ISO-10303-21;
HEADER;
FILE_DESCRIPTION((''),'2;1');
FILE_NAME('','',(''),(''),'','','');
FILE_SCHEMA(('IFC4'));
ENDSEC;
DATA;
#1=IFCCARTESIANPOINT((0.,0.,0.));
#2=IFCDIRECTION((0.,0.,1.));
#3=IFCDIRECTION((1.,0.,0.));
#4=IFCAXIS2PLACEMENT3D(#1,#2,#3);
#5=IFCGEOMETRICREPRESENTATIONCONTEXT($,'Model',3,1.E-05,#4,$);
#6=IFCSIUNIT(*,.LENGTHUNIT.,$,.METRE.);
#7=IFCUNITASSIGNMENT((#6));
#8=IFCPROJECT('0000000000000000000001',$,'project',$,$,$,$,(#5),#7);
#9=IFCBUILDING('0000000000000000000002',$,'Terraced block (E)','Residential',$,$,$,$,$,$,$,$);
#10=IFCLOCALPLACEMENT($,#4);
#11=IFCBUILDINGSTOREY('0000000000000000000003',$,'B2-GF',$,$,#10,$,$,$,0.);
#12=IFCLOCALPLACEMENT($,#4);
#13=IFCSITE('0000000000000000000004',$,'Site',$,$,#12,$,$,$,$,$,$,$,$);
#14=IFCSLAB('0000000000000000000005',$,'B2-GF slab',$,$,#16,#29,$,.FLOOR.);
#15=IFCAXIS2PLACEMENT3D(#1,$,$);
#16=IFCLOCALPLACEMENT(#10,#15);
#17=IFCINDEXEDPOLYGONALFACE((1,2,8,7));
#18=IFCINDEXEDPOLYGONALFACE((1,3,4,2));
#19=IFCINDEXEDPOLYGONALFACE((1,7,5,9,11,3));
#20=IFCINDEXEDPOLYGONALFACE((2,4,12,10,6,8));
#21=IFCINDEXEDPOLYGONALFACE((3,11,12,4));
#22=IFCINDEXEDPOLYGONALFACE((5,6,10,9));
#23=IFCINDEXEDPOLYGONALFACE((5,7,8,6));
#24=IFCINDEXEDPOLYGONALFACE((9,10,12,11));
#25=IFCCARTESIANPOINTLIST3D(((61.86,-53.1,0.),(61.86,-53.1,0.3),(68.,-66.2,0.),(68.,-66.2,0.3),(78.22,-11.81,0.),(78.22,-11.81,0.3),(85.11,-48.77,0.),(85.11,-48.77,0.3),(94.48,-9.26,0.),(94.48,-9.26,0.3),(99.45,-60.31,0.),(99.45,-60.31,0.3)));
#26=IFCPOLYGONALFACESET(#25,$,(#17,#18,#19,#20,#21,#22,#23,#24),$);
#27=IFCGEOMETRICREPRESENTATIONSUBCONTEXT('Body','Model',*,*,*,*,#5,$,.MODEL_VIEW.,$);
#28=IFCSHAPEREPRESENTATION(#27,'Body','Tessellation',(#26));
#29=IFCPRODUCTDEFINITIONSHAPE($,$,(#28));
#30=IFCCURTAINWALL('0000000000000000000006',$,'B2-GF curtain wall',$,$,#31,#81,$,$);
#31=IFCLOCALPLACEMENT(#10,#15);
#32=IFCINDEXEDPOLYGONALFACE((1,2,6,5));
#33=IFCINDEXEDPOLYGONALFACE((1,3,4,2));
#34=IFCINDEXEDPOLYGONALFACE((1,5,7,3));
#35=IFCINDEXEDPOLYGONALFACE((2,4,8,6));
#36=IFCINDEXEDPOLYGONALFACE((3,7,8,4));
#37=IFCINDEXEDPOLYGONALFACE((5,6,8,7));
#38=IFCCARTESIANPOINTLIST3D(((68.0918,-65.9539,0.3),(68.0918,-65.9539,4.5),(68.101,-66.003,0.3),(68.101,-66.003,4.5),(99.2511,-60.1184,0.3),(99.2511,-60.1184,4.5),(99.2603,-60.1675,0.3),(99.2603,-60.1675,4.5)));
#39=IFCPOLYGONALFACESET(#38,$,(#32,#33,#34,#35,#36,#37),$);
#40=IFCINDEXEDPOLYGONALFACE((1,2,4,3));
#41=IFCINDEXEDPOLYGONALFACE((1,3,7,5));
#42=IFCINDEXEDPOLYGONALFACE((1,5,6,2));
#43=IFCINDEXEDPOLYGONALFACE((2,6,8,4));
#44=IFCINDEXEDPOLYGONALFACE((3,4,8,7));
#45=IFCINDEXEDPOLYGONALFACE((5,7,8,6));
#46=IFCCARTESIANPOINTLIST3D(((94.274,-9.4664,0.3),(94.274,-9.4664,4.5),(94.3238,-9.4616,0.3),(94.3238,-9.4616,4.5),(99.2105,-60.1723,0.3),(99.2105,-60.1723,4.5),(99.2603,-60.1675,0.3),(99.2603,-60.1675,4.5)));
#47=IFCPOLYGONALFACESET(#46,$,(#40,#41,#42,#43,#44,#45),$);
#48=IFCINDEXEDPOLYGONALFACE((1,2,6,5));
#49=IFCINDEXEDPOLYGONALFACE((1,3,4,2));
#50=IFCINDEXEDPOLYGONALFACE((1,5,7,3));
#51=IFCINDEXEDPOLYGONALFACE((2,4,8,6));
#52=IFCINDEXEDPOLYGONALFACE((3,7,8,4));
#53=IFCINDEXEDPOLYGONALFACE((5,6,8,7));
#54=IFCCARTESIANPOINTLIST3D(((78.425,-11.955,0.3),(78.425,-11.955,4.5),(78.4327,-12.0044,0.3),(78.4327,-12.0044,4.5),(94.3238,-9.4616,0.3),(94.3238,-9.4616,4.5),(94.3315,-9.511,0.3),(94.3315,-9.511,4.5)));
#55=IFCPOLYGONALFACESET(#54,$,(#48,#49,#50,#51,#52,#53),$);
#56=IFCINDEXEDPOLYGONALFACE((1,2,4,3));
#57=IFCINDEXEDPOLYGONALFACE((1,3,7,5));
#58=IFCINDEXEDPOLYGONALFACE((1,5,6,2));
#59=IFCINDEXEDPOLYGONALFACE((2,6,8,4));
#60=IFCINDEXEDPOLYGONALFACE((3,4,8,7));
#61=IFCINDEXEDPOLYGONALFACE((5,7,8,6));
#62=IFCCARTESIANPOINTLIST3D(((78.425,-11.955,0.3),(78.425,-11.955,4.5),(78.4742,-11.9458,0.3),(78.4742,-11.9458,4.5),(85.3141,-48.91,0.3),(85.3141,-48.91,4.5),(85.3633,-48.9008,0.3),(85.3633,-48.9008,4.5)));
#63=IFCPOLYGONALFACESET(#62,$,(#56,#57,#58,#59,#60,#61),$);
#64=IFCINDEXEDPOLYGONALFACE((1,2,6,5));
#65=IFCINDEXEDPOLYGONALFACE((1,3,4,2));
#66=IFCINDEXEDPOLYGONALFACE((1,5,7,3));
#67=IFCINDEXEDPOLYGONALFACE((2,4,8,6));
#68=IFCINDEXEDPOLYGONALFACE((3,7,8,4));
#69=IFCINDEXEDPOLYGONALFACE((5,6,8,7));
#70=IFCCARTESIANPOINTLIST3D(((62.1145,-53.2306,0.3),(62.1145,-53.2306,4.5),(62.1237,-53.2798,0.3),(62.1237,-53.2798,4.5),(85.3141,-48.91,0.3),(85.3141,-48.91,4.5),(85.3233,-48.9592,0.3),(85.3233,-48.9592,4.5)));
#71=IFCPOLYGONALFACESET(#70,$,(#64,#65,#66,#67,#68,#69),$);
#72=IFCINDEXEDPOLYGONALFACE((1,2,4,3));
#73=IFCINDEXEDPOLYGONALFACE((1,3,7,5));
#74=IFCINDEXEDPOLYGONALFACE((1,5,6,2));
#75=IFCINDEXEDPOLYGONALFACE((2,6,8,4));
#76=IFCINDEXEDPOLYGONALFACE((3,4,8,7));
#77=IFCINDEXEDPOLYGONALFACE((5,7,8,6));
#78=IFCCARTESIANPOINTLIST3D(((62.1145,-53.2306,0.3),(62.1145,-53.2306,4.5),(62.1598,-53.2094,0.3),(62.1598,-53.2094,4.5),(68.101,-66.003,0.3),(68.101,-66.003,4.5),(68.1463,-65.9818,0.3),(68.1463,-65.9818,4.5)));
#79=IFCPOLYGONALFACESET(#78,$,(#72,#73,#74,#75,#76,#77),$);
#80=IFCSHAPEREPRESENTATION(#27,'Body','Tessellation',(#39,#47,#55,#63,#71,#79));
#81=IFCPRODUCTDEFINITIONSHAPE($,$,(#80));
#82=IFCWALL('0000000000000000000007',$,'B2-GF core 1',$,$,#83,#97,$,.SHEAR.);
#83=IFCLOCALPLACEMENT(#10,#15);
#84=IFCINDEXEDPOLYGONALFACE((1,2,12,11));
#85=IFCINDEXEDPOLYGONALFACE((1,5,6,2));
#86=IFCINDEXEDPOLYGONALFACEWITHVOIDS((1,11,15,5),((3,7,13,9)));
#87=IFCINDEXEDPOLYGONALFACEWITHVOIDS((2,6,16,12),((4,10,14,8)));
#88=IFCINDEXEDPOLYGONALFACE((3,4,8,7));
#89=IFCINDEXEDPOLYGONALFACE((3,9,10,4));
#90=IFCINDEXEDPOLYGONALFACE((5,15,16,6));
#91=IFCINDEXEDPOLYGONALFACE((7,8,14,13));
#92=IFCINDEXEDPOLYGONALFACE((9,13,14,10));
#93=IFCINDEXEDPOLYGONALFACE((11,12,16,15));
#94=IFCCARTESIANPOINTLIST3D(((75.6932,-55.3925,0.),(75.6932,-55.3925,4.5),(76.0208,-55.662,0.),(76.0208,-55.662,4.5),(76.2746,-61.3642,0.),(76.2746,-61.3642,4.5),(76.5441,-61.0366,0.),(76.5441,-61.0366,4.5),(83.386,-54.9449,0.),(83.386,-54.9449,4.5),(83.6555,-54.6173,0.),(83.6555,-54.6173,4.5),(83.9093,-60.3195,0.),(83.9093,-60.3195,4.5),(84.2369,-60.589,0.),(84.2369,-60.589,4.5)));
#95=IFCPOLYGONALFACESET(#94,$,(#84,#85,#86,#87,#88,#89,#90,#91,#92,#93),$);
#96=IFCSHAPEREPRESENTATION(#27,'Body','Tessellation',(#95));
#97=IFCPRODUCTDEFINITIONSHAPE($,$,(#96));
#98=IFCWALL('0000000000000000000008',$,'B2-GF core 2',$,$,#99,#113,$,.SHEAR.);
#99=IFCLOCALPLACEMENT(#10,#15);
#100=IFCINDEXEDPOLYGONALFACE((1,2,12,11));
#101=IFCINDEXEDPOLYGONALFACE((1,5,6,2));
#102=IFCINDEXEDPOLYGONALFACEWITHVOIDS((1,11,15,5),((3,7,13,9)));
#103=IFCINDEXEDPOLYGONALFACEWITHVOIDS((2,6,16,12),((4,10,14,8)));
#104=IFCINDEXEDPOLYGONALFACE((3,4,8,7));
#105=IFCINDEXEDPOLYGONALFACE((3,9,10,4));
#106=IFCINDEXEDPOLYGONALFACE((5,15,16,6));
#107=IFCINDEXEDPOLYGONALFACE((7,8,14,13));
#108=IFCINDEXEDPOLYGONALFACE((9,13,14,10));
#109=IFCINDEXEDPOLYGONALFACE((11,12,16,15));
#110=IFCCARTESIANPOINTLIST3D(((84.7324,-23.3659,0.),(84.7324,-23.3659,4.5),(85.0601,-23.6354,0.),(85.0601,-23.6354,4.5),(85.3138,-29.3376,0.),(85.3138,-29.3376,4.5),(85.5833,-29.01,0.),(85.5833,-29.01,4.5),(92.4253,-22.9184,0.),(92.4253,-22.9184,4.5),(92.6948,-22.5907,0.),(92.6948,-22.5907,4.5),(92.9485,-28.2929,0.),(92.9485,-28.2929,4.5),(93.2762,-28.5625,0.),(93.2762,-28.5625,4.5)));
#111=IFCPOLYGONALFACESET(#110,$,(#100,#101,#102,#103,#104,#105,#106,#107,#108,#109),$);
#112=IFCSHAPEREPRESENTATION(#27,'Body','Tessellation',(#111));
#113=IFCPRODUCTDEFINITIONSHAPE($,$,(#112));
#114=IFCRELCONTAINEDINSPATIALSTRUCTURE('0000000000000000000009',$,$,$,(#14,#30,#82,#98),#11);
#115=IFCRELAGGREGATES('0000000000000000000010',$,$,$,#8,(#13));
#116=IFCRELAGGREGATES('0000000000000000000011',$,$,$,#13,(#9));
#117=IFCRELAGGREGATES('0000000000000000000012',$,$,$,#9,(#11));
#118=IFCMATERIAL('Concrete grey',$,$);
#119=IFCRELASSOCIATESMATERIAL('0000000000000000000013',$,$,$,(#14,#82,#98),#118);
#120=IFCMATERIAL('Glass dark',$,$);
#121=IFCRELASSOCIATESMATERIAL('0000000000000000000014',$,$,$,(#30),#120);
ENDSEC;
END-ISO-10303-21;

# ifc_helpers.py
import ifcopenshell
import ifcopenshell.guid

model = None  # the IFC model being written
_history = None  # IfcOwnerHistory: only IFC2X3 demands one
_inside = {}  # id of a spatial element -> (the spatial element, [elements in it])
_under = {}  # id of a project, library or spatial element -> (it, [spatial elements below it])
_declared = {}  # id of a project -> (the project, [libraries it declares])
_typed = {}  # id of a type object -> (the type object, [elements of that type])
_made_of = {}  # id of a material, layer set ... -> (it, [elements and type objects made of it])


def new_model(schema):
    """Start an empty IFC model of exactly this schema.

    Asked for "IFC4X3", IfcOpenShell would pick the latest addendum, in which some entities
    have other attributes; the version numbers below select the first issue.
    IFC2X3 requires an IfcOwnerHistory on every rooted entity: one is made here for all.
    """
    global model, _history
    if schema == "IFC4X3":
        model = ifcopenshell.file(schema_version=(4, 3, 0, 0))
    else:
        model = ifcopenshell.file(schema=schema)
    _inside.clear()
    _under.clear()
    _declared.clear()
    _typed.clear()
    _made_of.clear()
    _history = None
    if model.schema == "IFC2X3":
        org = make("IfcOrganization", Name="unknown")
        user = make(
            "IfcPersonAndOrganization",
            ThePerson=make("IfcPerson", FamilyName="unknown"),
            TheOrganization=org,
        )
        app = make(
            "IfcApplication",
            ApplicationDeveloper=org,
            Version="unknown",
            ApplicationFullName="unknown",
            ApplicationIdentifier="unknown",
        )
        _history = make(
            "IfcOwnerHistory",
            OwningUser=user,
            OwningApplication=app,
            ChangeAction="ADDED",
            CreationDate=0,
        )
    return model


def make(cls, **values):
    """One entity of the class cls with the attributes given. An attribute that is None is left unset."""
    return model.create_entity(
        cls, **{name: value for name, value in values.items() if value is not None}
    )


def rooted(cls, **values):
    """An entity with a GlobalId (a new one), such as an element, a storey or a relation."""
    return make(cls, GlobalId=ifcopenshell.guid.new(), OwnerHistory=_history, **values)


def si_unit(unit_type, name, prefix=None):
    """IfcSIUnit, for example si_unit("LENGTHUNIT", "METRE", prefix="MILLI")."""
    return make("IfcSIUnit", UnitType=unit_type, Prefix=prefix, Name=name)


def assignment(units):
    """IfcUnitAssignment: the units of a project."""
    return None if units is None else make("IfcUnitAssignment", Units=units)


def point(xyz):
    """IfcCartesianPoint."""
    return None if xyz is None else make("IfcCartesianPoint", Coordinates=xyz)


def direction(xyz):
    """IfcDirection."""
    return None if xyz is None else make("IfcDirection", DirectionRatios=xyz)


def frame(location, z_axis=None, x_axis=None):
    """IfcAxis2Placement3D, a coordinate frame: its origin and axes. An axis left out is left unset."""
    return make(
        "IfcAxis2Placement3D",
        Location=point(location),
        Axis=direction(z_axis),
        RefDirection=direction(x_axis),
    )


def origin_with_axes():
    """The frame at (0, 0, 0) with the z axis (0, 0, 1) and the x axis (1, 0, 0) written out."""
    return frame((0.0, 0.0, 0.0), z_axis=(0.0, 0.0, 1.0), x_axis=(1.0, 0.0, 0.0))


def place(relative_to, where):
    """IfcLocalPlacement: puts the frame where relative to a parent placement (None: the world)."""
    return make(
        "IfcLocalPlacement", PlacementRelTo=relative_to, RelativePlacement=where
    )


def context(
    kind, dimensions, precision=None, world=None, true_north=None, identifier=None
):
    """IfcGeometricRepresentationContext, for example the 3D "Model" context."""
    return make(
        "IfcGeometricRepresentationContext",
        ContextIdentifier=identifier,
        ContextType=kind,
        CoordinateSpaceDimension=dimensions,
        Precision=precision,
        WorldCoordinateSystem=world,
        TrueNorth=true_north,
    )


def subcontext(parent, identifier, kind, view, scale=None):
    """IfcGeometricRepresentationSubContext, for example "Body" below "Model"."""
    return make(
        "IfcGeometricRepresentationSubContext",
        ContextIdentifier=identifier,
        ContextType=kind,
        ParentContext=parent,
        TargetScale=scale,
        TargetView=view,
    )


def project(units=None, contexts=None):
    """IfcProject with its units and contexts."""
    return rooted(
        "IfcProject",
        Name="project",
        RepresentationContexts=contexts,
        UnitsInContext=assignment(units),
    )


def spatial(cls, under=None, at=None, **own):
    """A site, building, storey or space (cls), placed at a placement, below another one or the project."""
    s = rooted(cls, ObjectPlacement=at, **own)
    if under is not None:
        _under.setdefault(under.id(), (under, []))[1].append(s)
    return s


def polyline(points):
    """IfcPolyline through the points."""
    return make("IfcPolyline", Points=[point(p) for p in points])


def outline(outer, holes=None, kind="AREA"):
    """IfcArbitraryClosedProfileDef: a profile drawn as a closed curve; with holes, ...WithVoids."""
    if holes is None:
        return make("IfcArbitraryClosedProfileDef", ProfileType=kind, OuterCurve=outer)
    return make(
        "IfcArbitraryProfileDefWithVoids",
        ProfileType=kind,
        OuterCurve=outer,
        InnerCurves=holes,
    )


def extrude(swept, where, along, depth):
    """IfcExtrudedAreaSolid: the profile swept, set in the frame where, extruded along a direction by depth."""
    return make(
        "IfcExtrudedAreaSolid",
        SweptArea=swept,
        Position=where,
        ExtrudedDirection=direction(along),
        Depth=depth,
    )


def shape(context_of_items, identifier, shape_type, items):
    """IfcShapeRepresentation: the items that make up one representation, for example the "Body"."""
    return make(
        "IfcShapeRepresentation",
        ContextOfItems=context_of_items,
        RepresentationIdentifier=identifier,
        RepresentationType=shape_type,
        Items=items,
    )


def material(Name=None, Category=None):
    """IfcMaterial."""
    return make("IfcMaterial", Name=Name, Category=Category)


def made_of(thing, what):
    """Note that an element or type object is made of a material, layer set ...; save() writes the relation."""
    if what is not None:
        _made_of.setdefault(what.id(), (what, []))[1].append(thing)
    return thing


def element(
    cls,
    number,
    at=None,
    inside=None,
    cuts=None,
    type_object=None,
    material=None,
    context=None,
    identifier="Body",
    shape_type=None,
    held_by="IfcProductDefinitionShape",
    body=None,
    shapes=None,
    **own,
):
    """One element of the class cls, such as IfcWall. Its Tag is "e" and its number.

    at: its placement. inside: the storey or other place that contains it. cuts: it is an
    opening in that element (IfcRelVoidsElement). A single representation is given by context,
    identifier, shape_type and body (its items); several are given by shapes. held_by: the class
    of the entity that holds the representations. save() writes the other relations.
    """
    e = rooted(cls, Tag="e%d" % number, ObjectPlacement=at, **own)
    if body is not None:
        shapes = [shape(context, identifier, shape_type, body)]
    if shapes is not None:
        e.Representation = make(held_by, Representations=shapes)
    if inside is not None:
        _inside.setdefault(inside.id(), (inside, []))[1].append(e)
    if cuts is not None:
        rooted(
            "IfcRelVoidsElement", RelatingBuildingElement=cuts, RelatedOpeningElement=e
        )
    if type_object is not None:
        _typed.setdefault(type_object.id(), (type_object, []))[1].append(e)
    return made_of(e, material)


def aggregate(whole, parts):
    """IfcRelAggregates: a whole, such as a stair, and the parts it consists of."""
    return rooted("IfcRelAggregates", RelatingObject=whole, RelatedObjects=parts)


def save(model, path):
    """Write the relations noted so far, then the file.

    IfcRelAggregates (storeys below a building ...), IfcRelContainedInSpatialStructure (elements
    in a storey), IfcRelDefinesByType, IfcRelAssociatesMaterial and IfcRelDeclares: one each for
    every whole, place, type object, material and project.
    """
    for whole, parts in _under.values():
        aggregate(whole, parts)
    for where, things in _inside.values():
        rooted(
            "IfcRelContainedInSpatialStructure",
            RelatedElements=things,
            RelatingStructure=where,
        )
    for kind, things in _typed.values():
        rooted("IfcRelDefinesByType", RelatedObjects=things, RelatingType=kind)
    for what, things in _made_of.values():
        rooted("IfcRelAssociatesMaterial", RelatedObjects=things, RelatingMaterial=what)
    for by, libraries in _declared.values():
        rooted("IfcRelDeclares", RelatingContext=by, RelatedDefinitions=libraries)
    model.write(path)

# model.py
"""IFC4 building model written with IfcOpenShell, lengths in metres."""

from ifc_helpers import new_model, si_unit, frame, origin_with_axes, place, context, subcontext, project, spatial, polyline, outline, extrude, material, element, save


model = new_model("IFC4")

# Units and contexts
model_context = context("Model", 3, precision=1e-05, world=origin_with_axes())
body_context = subcontext(model_context, "Body", "Model", "MODEL_VIEW")
ifc_project = project(units=[si_unit("LENGTHUNIT", "METRE")], contexts=[model_context])

# Site, building, storey
site_placement = place(None, origin_with_axes())
site = spatial("IfcSite", under=ifc_project, at=site_placement, Name="Site")
building = spatial("IfcBuilding", under=site, Name="Terraced block (E)", Description="Residential")
storey_placement = place(None, origin_with_axes())
storey = spatial("IfcBuildingStorey", under=building, at=storey_placement, Name="B2-GF", Elevation=0.0)

# Slab
ifc_material_1 = material(Name="Concrete grey")
slab_placement = place(storey_placement, origin_with_axes())
element("IfcSlab", 1, at=slab_placement, inside=storey, material=ifc_material_1, Name="B2-GF slab", PredefinedType="FLOOR", context=body_context, shape_type="SweptSolid", body=[
    extrude(outline(polyline([(68.0, -66.2), (99.45, -60.31), (94.48, -9.26), (78.22, -11.81), (85.11, -48.77), (61.86, -53.1), (68.0, -66.2)])), origin_with_axes(), (0.0, 0.0, 1.0), 0.3),
])

# Curtain wall
ifc_material_2 = material(Name="Glass dark")
curtain_wall_placement = place(storey_placement, origin_with_axes())
element("IfcCurtainWall", 2, at=curtain_wall_placement, inside=storey, material=ifc_material_2, Name="B2-GF curtain wall", context=body_context, shape_type="SweptSolid", body=[
    extrude(outline(polyline([(68.101, -66.003), (99.2603, -60.1675), (99.2511, -60.1184), (68.0918, -65.9539), (68.101, -66.003)])), frame((0.0, 0.0, 0.3), z_axis=(0.0, 0.0, 1.0), x_axis=(1.0, 0.0, 0.0)), (0.0, 0.0, 1.0), 4.2),
    extrude(outline(polyline([(99.2603, -60.1675), (94.3238, -9.4616), (94.274, -9.4664), (99.2105, -60.1723), (99.2603, -60.1675)])), frame((0.0, 0.0, 0.3), z_axis=(0.0, 0.0, 1.0), x_axis=(1.0, 0.0, 0.0)), (0.0, 0.0, 1.0), 4.2),
    extrude(outline(polyline([(94.3238, -9.4616), (78.425, -11.955), (78.4327, -12.0044), (94.3315, -9.511), (94.3238, -9.4616)])), frame((0.0, 0.0, 0.3), z_axis=(0.0, 0.0, 1.0), x_axis=(1.0, 0.0, 0.0)), (0.0, 0.0, 1.0), 4.2),
    extrude(outline(polyline([(78.425, -11.955), (85.3141, -48.91), (85.3633, -48.9008), (78.4742, -11.9458), (78.425, -11.955)])), frame((0.0, 0.0, 0.3), z_axis=(0.0, 0.0, 1.0), x_axis=(1.0, 0.0, 0.0)), (0.0, 0.0, 1.0), 4.2),
    extrude(outline(polyline([(85.3141, -48.91), (62.1145, -53.2306), (62.1237, -53.2798), (85.3233, -48.9592), (85.3141, -48.91)])), frame((0.0, 0.0, 0.3), z_axis=(0.0, 0.0, 1.0), x_axis=(1.0, 0.0, 0.0)), (0.0, 0.0, 1.0), 4.2),
    extrude(outline(polyline([(62.1145, -53.2306), (68.101, -66.003), (68.1463, -65.9818), (62.1598, -53.2094), (62.1145, -53.2306)])), frame((0.0, 0.0, 0.3), z_axis=(0.0, 0.0, 1.0), x_axis=(1.0, 0.0, 0.0)), (0.0, 0.0, 1.0), 4.2),
])

# Walls
wall_1_placement = place(storey_placement, origin_with_axes())
element("IfcWall", 3, at=wall_1_placement, inside=storey, material=ifc_material_1, Name="B2-GF core 1", PredefinedType="SHEAR", context=body_context, shape_type="SweptSolid", body=[
    extrude(outline(polyline([(84.2369, -60.589), (83.6555, -54.6173), (75.6932, -55.3925), (76.2746, -61.3642), (84.2369, -60.589)]), holes=[polyline([(83.9093, -60.3195), (83.386, -54.9449), (76.0208, -55.662), (76.5441, -61.0366), (83.9093, -60.3195)])]), origin_with_axes(), (0.0, 0.0, 1.0), 4.5),
])
wall_2_placement = place(storey_placement, origin_with_axes())
element("IfcWall", 4, at=wall_2_placement, inside=storey, material=ifc_material_1, Name="B2-GF core 2", PredefinedType="SHEAR", context=body_context, shape_type="SweptSolid", body=[
    extrude(outline(polyline([(93.2762, -28.5625), (92.6948, -22.5907), (84.7324, -23.3659), (85.3138, -29.3376), (93.2762, -28.5625)]), holes=[polyline([(92.9485, -28.2929), (92.4253, -22.9184), (85.0601, -23.6354), (85.5833, -29.01), (92.9485, -28.2929)])]), origin_with_axes(), (0.0, 0.0, 1.0), 4.5),
])

save(model, "model.ifc")
